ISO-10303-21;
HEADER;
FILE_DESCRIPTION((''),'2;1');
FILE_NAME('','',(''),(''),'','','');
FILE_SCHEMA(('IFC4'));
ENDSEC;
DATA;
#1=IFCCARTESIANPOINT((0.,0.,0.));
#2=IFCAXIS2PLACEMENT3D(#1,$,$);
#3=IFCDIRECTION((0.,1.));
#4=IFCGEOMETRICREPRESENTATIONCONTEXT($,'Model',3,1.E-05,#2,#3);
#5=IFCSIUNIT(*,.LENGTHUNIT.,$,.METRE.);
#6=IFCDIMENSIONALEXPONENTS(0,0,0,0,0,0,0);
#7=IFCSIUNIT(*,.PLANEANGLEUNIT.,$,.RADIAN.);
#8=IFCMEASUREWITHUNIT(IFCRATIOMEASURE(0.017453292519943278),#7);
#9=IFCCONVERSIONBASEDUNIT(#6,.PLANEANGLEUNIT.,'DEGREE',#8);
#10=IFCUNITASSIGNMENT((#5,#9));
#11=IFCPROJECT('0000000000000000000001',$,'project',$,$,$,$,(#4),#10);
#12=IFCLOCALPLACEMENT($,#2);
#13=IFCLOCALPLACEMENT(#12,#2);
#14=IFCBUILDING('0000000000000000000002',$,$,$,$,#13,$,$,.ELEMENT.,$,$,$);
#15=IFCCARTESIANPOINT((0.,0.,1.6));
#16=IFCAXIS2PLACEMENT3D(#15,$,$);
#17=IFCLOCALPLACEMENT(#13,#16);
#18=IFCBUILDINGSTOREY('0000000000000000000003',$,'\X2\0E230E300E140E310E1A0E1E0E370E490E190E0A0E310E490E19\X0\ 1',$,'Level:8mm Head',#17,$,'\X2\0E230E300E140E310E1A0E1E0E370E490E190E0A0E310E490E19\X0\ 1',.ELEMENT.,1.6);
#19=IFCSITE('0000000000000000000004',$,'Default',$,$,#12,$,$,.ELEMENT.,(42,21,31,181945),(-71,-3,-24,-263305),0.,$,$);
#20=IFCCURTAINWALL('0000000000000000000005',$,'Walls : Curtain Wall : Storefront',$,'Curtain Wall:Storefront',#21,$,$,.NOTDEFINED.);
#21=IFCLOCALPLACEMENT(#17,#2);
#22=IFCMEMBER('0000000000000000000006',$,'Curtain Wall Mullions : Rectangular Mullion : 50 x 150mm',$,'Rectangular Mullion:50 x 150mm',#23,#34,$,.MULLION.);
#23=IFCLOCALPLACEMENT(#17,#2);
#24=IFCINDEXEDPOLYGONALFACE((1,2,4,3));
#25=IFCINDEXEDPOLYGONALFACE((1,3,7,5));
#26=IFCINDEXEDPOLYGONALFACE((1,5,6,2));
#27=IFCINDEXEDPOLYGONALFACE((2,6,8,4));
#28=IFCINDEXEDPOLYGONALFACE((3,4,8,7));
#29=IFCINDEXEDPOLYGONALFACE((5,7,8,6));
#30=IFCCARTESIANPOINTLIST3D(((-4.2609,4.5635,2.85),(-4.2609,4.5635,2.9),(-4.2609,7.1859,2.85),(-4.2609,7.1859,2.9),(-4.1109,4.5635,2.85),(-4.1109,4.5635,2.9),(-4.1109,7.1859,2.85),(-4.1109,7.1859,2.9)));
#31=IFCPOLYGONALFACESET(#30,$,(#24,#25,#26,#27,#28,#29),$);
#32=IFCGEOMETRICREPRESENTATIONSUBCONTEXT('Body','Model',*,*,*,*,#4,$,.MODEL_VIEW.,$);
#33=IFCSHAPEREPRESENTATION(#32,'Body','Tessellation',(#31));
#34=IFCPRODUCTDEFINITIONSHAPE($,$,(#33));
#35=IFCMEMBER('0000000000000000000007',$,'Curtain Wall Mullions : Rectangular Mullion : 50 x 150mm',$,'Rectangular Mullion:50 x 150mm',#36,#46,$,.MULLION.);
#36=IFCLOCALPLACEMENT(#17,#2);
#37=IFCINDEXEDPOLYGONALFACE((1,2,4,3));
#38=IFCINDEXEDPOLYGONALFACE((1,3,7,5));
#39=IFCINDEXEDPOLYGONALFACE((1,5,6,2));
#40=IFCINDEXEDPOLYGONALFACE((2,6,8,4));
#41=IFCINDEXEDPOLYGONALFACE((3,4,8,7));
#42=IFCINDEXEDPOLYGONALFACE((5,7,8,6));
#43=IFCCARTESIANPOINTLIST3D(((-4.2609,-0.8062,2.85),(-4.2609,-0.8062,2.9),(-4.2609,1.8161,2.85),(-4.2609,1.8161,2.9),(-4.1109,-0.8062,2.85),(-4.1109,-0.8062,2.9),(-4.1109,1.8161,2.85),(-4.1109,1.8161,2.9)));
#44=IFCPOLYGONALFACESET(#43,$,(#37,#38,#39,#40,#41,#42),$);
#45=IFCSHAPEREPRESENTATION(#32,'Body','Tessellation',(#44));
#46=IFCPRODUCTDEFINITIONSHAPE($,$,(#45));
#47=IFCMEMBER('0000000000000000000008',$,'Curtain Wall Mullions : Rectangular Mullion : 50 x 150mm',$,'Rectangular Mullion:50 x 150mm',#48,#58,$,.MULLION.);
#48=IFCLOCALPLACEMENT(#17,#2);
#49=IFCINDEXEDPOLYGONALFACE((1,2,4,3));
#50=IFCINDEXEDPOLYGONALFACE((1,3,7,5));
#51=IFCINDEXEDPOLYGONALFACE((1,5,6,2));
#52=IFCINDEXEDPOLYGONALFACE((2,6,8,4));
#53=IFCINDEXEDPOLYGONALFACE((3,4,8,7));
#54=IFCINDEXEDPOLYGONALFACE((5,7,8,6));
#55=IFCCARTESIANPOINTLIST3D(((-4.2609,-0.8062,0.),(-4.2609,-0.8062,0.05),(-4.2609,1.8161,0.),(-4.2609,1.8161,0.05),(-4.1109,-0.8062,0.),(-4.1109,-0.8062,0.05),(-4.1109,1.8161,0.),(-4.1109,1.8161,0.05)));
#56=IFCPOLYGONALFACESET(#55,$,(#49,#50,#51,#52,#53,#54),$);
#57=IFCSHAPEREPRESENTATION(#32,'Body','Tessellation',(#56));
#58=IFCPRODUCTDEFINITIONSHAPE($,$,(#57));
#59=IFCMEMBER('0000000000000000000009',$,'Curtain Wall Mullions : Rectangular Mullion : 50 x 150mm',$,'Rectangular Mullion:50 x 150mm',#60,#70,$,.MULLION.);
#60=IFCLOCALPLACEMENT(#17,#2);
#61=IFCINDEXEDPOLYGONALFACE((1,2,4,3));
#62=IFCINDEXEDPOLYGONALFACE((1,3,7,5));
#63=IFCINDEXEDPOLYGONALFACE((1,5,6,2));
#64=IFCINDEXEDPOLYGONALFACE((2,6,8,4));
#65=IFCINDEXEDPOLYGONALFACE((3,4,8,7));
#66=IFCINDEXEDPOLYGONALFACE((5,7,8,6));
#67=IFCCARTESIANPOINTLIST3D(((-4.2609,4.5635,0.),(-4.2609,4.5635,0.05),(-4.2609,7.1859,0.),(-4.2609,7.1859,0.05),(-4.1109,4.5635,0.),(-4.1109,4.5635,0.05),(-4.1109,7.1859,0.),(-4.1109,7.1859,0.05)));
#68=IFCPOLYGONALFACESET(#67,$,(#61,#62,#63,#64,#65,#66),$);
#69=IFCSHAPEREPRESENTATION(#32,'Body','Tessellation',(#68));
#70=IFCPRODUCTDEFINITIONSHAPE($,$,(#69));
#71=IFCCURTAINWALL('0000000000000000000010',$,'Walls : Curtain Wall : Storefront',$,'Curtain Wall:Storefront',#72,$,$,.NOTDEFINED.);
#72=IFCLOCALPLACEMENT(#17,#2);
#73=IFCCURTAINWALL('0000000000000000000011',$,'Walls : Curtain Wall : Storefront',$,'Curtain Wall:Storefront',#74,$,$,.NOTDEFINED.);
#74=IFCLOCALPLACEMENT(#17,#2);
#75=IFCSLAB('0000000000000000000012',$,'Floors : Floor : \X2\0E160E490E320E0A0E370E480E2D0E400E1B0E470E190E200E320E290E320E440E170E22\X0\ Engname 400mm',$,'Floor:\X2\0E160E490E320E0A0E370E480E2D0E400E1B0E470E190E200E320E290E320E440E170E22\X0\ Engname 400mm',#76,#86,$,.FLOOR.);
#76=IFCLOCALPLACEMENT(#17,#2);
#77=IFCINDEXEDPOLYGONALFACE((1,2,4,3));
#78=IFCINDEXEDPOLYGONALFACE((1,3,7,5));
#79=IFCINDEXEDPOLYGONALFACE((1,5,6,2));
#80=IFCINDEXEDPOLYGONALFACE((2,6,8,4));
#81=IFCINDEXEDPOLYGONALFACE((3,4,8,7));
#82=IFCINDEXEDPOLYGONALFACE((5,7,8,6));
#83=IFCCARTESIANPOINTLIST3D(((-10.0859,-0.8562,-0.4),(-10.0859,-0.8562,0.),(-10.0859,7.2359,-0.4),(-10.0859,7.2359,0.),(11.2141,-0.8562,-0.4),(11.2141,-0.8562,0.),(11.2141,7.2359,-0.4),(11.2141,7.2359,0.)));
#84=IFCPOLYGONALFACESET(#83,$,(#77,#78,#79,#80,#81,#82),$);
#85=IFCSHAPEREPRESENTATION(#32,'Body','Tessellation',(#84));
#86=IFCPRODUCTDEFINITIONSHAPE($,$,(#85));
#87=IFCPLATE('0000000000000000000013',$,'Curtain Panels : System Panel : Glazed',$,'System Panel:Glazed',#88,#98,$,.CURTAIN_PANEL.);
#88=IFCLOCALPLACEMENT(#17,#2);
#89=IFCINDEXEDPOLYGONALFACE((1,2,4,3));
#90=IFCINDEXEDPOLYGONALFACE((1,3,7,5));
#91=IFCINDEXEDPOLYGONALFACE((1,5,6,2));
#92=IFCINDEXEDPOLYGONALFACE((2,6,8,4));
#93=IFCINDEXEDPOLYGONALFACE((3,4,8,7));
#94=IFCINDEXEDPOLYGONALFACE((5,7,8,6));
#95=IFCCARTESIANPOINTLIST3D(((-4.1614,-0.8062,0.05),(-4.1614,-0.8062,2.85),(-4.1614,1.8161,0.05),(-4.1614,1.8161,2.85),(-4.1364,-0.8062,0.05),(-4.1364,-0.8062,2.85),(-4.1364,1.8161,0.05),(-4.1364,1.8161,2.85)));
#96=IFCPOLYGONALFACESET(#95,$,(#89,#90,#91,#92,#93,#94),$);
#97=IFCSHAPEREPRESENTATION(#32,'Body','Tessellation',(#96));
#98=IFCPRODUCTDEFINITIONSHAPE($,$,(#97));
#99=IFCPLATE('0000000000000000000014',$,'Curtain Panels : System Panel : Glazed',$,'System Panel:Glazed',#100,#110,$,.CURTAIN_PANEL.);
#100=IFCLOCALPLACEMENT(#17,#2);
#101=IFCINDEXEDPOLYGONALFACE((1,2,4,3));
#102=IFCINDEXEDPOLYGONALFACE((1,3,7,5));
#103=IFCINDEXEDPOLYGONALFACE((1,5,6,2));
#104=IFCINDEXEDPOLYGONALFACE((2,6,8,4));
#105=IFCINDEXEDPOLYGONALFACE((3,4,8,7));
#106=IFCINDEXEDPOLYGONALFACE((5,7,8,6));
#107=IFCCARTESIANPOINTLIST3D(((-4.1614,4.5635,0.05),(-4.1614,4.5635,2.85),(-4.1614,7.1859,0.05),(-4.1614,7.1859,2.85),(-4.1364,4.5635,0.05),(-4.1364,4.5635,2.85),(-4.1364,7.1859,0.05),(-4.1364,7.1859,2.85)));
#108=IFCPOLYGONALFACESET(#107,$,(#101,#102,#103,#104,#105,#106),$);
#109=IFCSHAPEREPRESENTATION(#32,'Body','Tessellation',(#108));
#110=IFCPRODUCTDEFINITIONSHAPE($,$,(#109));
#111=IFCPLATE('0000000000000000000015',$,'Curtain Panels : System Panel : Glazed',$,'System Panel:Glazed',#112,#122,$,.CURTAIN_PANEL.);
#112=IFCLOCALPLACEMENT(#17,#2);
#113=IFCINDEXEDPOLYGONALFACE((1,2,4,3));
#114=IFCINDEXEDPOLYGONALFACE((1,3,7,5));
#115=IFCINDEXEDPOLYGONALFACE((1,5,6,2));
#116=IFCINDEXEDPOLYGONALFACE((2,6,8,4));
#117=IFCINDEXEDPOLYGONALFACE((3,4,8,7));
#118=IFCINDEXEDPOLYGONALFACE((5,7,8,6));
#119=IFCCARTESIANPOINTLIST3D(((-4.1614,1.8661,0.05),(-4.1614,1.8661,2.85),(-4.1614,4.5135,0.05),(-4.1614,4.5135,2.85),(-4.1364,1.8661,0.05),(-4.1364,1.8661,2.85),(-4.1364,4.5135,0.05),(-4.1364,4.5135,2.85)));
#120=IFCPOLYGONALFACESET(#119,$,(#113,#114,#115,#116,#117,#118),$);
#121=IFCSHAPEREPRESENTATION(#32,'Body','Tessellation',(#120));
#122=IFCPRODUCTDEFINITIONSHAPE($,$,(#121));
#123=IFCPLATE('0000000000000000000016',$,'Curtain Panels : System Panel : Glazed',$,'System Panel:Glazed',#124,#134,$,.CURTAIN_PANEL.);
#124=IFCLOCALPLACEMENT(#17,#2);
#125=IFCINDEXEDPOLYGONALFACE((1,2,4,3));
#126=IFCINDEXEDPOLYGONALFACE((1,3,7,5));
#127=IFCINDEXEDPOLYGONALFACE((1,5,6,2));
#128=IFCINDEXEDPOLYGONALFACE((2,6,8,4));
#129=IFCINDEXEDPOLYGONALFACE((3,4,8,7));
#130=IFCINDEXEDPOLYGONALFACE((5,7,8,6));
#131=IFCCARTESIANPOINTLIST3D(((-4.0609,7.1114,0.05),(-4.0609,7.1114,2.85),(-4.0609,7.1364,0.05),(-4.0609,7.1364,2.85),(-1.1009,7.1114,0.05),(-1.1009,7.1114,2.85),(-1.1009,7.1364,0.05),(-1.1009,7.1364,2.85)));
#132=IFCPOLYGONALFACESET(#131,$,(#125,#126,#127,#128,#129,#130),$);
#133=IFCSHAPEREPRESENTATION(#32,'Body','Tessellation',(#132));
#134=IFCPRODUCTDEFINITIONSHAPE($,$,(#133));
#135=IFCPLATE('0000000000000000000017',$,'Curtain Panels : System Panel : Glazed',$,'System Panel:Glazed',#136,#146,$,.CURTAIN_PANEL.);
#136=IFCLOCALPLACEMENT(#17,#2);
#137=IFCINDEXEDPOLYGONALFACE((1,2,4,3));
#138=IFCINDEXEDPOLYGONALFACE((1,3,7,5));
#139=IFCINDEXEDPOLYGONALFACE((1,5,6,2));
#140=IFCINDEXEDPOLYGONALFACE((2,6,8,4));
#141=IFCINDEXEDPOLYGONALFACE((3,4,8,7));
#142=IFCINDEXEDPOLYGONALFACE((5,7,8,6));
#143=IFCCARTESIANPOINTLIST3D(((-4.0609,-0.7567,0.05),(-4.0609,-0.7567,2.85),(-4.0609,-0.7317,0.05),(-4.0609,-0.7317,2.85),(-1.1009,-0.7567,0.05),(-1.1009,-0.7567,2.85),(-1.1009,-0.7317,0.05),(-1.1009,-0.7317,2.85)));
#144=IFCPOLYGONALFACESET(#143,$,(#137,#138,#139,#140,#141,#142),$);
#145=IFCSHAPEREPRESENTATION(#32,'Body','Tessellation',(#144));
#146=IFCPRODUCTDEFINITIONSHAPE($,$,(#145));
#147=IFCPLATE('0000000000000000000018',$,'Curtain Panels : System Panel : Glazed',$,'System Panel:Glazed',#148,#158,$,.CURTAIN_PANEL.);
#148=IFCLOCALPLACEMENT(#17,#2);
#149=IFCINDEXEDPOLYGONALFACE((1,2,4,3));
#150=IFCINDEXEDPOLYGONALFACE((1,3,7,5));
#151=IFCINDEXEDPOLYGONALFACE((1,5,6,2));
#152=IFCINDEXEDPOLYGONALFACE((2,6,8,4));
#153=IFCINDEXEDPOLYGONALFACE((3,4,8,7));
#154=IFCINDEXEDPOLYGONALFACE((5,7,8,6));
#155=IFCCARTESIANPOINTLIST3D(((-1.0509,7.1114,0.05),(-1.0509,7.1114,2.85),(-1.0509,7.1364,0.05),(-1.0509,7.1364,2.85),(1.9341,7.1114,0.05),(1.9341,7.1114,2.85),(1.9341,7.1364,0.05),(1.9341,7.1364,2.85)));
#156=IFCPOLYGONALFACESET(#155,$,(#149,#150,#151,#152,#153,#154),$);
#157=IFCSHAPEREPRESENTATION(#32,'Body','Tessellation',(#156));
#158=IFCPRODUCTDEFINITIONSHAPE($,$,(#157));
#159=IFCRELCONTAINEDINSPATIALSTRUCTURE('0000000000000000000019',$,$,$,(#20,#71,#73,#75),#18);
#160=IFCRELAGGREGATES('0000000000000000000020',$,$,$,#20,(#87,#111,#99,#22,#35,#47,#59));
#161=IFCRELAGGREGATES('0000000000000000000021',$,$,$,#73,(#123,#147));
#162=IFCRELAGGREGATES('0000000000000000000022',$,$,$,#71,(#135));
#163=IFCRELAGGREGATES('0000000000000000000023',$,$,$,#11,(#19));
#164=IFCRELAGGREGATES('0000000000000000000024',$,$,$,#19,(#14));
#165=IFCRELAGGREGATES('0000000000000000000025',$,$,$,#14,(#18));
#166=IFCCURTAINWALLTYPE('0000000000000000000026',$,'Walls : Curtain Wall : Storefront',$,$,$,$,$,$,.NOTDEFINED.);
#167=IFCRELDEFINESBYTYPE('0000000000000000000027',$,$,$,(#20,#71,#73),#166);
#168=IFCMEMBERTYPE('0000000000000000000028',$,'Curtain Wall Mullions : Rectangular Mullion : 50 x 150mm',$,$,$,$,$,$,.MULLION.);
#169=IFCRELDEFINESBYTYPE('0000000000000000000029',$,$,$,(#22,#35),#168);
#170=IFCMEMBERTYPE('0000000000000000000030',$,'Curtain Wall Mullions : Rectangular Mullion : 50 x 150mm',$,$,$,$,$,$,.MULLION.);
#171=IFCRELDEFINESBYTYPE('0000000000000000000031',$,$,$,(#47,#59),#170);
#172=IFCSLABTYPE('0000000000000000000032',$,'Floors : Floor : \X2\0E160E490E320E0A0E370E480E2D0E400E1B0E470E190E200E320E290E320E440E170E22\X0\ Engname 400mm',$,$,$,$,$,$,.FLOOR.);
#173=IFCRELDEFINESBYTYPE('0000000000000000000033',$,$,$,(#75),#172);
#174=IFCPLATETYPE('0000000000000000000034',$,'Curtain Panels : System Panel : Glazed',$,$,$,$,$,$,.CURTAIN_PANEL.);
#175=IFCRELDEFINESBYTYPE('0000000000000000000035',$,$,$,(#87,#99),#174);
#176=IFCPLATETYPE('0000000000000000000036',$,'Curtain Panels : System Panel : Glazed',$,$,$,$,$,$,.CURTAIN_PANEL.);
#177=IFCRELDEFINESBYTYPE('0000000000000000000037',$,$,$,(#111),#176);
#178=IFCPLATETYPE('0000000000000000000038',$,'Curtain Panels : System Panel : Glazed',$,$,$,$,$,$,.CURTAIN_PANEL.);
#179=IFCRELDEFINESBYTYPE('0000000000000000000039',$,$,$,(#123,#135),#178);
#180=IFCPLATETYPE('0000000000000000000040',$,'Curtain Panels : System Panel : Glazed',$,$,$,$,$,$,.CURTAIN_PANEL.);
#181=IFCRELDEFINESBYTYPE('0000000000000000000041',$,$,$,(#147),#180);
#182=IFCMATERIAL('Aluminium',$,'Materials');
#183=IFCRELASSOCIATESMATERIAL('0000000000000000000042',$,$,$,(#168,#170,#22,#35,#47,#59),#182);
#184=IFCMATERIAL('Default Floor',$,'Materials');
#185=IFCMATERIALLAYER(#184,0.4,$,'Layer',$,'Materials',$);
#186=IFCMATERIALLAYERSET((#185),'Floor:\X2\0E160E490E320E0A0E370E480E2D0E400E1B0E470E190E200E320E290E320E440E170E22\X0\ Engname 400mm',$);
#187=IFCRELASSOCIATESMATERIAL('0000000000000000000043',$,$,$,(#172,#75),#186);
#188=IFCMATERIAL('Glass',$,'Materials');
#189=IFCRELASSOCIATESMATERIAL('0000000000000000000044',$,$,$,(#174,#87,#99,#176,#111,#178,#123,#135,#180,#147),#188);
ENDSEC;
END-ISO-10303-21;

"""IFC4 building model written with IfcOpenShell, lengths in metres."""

from ifc_helpers import new_model, entity, si_unit, converted_unit, direction, frame, frame_2d, origin, origin_2d_with_axis, place, context, subcontext, project, spatial, polyline, segment, composite_curve, rectangle, outline, extrude, source, transform, mapped, material, layer, layer_set, layer_usage, material_profile, profile_set, profile_usage, type_object, type_shapes, element, aggregate, save


model = new_model("IFC4")

# Units and contexts
model_context = context("Model", 3, precision=1e-05, world=origin(), true_north=direction((0.0, 1.0)))
body_context = subcontext(model_context, "Body", "Model", "MODEL_VIEW")
ifc_project = project(units=[si_unit("LENGTHUNIT", "METRE"), converted_unit("PLANEANGLEUNIT", "DEGREE", entity("IfcRatioMeasure", 0.017453292519943278), si_unit("PLANEANGLEUNIT", "RADIAN"), dimensions=[0, 0, 0, 0, 0, 0, 0])], contexts=[model_context])

# Site, building, storey
site_placement = place(None, origin())
site = spatial("IfcSite", under=ifc_project, at=site_placement, Name="Default", CompositionType="ELEMENT", RefLatitude=(42, 21, 31, 181945), RefLongitude=(-71, -3, -24, -263305), RefElevation=0.0)
building_placement = place(site_placement, origin())
building = spatial("IfcBuilding", under=site, at=building_placement, CompositionType="ELEMENT")
storey_placement = place(building_placement, frame((0.0, 0.0, 1.6)))
storey = spatial("IfcBuildingStorey", under=building, at=storey_placement, Name="ระดับพื้นชั้น 1", ObjectType="Level:8mm Head", LongName="ระดับพื้นชั้น 1", CompositionType="ELEMENT", Elevation=1.6)

# Curtain wall, members
curtain_wall_type = type_object("IfcCurtainWallType", Name="Walls : Curtain Wall : Storefront", PredefinedType="NOTDEFINED")
curtain_wall_1_placement = place(storey_placement, frame((0.0, 0.0, -1.6)))
curtain_wall_1 = element("IfcCurtainWall", 1, at=curtain_wall_1_placement, inside=storey, type_object=curtain_wall_type, Name="Walls : Curtain Wall : Storefront", ObjectType="Curtain Wall:Storefront", PredefinedType="NOTDEFINED")
ifc_material_1 = material(Name="Aluminium", Category="Materials")
ifc_material_profile = material_profile(ifc_material_1, outline(composite_curve([segment(polyline([(0.0, 0.075, -2.6224), (0.0, -0.075, -2.6224)]), True, "CONTINUOUS"), segment(polyline([(0.0, -0.075, -2.6224), (-0.05, -0.075, -2.6224)]), True, "CONTINUOUS"), segment(polyline([(-0.05, -0.075, -2.6224), (-0.05, 0.075, -2.6224)]), True, "CONTINUOUS"), segment(polyline([(-0.05, 0.075, -2.6224), (0.0, 0.075, -2.6224)]), True, "CONTINUOUS")], self_intersect=False), kind="CURVE"), Name="50 x 150mm")
ifc_profile_set = profile_set([ifc_material_profile], Name="50 x 150mm")
ifc_profile_usage_1 = profile_usage(ifc_profile_set)
member_type_1 = type_object("IfcMemberType", Name="Curtain Wall Mullions : Rectangular Mullion : 50 x 150mm", PredefinedType="MULLION", material=ifc_profile_set)
shared_shape_1 = source(origin(), body_context, "Body", "SweptSolid", [
    extrude(rectangle(XDim=0.15, YDim=0.05, at=origin_2d_with_axis()), frame((-0.025, 0.0, -2.6224), z_axis=(0.0, 0.0, 1.0), x_axis=(0.0, -1.0, 0.0)), (0.0, 0.0, 1.0), 2.6224),
])
type_shapes(member_type_1, [shared_shape_1])
member_1_placement = place(curtain_wall_1_placement, frame((-4.1859, 7.1859, 4.5), z_axis=(0.0, 1.0, 0.0), x_axis=(0.0, 0.0, 1.0)))
member_1 = element("IfcMember", 2, at=member_1_placement, type_object=member_type_1, material=ifc_profile_usage_1, Name="Curtain Wall Mullions : Rectangular Mullion : 50 x 150mm", ObjectType="Rectangular Mullion:50 x 150mm", PredefinedType="MULLION", context=body_context, shape_type="MappedRepresentation", body=[
    mapped(shared_shape_1, transform((0.0, 0.0, 0.0), scale=1.0)),
])
ifc_profile_usage_2 = profile_usage(ifc_profile_set)
member_2_placement = place(curtain_wall_1_placement, frame((-4.1859, 1.8161, 4.5), z_axis=(0.0, 1.0, 0.0), x_axis=(0.0, 0.0, 1.0)))
member_2 = element("IfcMember", 3, at=member_2_placement, type_object=member_type_1, material=ifc_profile_usage_2, Name="Curtain Wall Mullions : Rectangular Mullion : 50 x 150mm", ObjectType="Rectangular Mullion:50 x 150mm", PredefinedType="MULLION", context=body_context, shape_type="MappedRepresentation", body=[
    mapped(shared_shape_1, transform((0.0, 0.0, 0.0), scale=1.0)),
])
ifc_profile_usage_3 = profile_usage(ifc_profile_set)
member_type_2 = type_object("IfcMemberType", Name="Curtain Wall Mullions : Rectangular Mullion : 50 x 150mm", PredefinedType="MULLION", material=ifc_profile_set)
shared_shape_2 = source(origin(), body_context, "Body", "SweptSolid", [
    extrude(rectangle(XDim=0.15, YDim=0.05, at=origin_2d_with_axis()), frame((-0.025, 0.0, -2.6224), z_axis=(0.0, 0.0, 1.0), x_axis=(0.0, -1.0, 0.0)), (0.0, 0.0, 1.0), 2.6224),
])
type_shapes(member_type_2, [shared_shape_2])
member_3_placement = place(curtain_wall_1_placement, frame((-4.1859, -0.8062, 1.6), z_axis=(0.0, -1.0, 0.0), x_axis=(0.0, 0.0, -1.0)))
member_3 = element("IfcMember", 4, at=member_3_placement, type_object=member_type_2, material=ifc_profile_usage_3, Name="Curtain Wall Mullions : Rectangular Mullion : 50 x 150mm", ObjectType="Rectangular Mullion:50 x 150mm", PredefinedType="MULLION", context=body_context, shape_type="MappedRepresentation", body=[
    mapped(shared_shape_2, transform((0.0, 0.0, 0.0), scale=1.0)),
])
ifc_profile_usage_4 = profile_usage(ifc_profile_set)
member_4_placement = place(curtain_wall_1_placement, frame((-4.1859, 4.5635, 1.6), z_axis=(0.0, -1.0, 0.0), x_axis=(0.0, 0.0, -1.0)))
member_4 = element("IfcMember", 5, at=member_4_placement, type_object=member_type_2, material=ifc_profile_usage_4, Name="Curtain Wall Mullions : Rectangular Mullion : 50 x 150mm", ObjectType="Rectangular Mullion:50 x 150mm", PredefinedType="MULLION", context=body_context, shape_type="MappedRepresentation", body=[
    mapped(shared_shape_2, transform((0.0, 0.0, 0.0), scale=1.0)),
])

# Curtain wall
curtain_wall_2_placement = place(storey_placement, frame((0.0, 0.0, -1.6)))
curtain_wall_2 = element("IfcCurtainWall", 6, at=curtain_wall_2_placement, inside=storey, type_object=curtain_wall_type, Name="Walls : Curtain Wall : Storefront", ObjectType="Curtain Wall:Storefront", PredefinedType="NOTDEFINED")

# Curtain wall
curtain_wall_3_placement = place(storey_placement, frame((0.0, 0.0, -1.6)))
curtain_wall_3 = element("IfcCurtainWall", 7, at=curtain_wall_3_placement, inside=storey, type_object=curtain_wall_type, Name="Walls : Curtain Wall : Storefront", ObjectType="Curtain Wall:Storefront", PredefinedType="NOTDEFINED")

# Slab
ifc_material_2 = material(Name="Default Floor", Category="Materials")
ifc_layer = layer(ifc_material_2, 0.4, Name="Layer", Category="Materials")
ifc_layer_set = layer_set([ifc_layer], Name="Floor:ถ้าชื่อเป็นภาษาไทย Engname 400mm")
ifc_layer_usage = layer_usage(ifc_layer_set, "AXIS3", "POSITIVE", 0.0)
slab_type = type_object("IfcSlabType", Name="Floors : Floor : ถ้าชื่อเป็นภาษาไทย Engname 400mm", PredefinedType="FLOOR", material=ifc_layer_set)
slab_placement = place(storey_placement, origin())
element("IfcSlab", 8, at=slab_placement, inside=storey, type_object=slab_type, material=ifc_layer_usage, Name="Floors : Floor : ถ้าชื่อเป็นภาษาไทย Engname 400mm", ObjectType="Floor:ถ้าชื่อเป็นภาษาไทย Engname 400mm", PredefinedType="FLOOR", context=body_context, shape_type="SweptSolid", body=[
    extrude(rectangle(XDim=8.0921, YDim=21.3, at=origin_2d_with_axis()), frame((0.5641, 3.1898, 0.0), z_axis=(0.0, 0.0, -1.0), x_axis=(0.0, 1.0, 0.0)), (0.0, 0.0, 1.0), 0.4),
])

# Plates
ifc_material_3 = material(Name="Glass", Category="Materials")
plate_type_1 = type_object("IfcPlateType", Name="Curtain Panels : System Panel : Glazed", PredefinedType="CURTAIN_PANEL", material=ifc_material_3)
shared_shape_3 = source(origin(), body_context, "Body", "SweptSolid", [
    extrude(rectangle(XDim=0.025, YDim=2.6224, at=frame_2d((0.0, 0.0), x_axis=(1.0, 0.0))), frame((1.3112, 0.0125, 0.0), z_axis=(0.0, 0.0, 1.0), x_axis=(0.0, 1.0, 0.0)), (0.0, 0.0, 1.0), 2.8),
])
type_shapes(plate_type_1, [shared_shape_3])
plate_1_placement = place(curtain_wall_1_placement, frame((-4.1364, -0.8062, 1.65), z_axis=(0.0, 0.0, 1.0), x_axis=(0.0, 1.0, 0.0)))
plate_1 = element("IfcPlate", 9, at=plate_1_placement, type_object=plate_type_1, material=ifc_material_3, Name="Curtain Panels : System Panel : Glazed", ObjectType="System Panel:Glazed", PredefinedType="CURTAIN_PANEL", context=body_context, shape_type="MappedRepresentation", body=[
    mapped(shared_shape_3, transform((0.0, 0.0, 0.0), scale=1.0)),
])
plate_2_placement = place(curtain_wall_1_placement, frame((-4.1364, 4.5635, 1.65), z_axis=(0.0, 0.0, 1.0), x_axis=(0.0, 1.0, 0.0)))
plate_2 = element("IfcPlate", 10, at=plate_2_placement, type_object=plate_type_1, material=ifc_material_3, Name="Curtain Panels : System Panel : Glazed", ObjectType="System Panel:Glazed", PredefinedType="CURTAIN_PANEL", context=body_context, shape_type="MappedRepresentation", body=[
    mapped(shared_shape_3, transform((0.0, 0.0, 0.0), scale=1.0)),
])
plate_type_2 = type_object("IfcPlateType", Name="Curtain Panels : System Panel : Glazed", PredefinedType="CURTAIN_PANEL", material=ifc_material_3)
shared_shape_4 = source(origin(), body_context, "Body", "SweptSolid", [
    extrude(rectangle(XDim=0.025, YDim=2.6474, at=origin_2d_with_axis()), frame((1.3237, 0.0125, 0.0), z_axis=(0.0, 0.0, 1.0), x_axis=(0.0, 1.0, 0.0)), (0.0, 0.0, 1.0), 2.8),
])
type_shapes(plate_type_2, [shared_shape_4])
plate_3_placement = place(curtain_wall_1_placement, frame((-4.1364, 1.8661, 1.65), z_axis=(0.0, 0.0, 1.0), x_axis=(0.0, 1.0, 0.0)))
plate_3 = element("IfcPlate", 11, at=plate_3_placement, type_object=plate_type_2, material=ifc_material_3, Name="Curtain Panels : System Panel : Glazed", ObjectType="System Panel:Glazed", PredefinedType="CURTAIN_PANEL", context=body_context, shape_type="MappedRepresentation", body=[
    mapped(shared_shape_4, transform((0.0, 0.0, 0.0), scale=1.0)),
])
aggregate(curtain_wall_1, [plate_1, plate_3, plate_2, member_1, member_2, member_3, member_4])
plate_type_3 = type_object("IfcPlateType", Name="Curtain Panels : System Panel : Glazed", PredefinedType="CURTAIN_PANEL", material=ifc_material_3)
shared_shape_5 = source(origin(), body_context, "Body", "SweptSolid", [
    extrude(rectangle(XDim=0.025, YDim=2.96, at=frame_2d((0.0, 0.0), x_axis=(1.0, 0.0))), frame((1.48, 0.0125, 0.0), z_axis=(0.0, 0.0, 1.0), x_axis=(0.0, 1.0, 0.0)), (0.0, 0.0, 1.0), 2.8),
])
type_shapes(plate_type_3, [shared_shape_5])
plate_4_placement = place(curtain_wall_3_placement, frame((-4.0609, 7.1114, 1.65)))
plate_4 = element("IfcPlate", 12, at=plate_4_placement, type_object=plate_type_3, material=ifc_material_3, Name="Curtain Panels : System Panel : Glazed", ObjectType="System Panel:Glazed", PredefinedType="CURTAIN_PANEL", context=body_context, shape_type="MappedRepresentation", body=[
    mapped(shared_shape_5, transform((0.0, 0.0, 0.0), scale=1.0)),
])
plate_5_placement = place(curtain_wall_2_placement, frame((-1.1009, -0.7317, 1.65), z_axis=(0.0, 0.0, 1.0), x_axis=(-1.0, 0.0, 0.0)))
plate_5 = element("IfcPlate", 13, at=plate_5_placement, type_object=plate_type_3, material=ifc_material_3, Name="Curtain Panels : System Panel : Glazed", ObjectType="System Panel:Glazed", PredefinedType="CURTAIN_PANEL", context=body_context, shape_type="MappedRepresentation", body=[
    mapped(shared_shape_5, transform((0.0, 0.0, 0.0), scale=1.0)),
])
plate_type_4 = type_object("IfcPlateType", Name="Curtain Panels : System Panel : Glazed", PredefinedType="CURTAIN_PANEL", material=ifc_material_3)
shared_shape_6 = source(origin(), body_context, "Body", "SweptSolid", [
    extrude(rectangle(XDim=0.025, YDim=2.985, at=frame_2d((0.0, 0.0), x_axis=(1.0, 0.0))), frame((1.4925, 0.0125, 0.0), z_axis=(0.0, 0.0, 1.0), x_axis=(0.0, 1.0, 0.0)), (0.0, 0.0, 1.0), 2.8),
])
type_shapes(plate_type_4, [shared_shape_6])
plate_6_placement = place(curtain_wall_3_placement, frame((-1.0509, 7.1114, 1.65)))
plate_6 = element("IfcPlate", 14, at=plate_6_placement, type_object=plate_type_4, material=ifc_material_3, Name="Curtain Panels : System Panel : Glazed", ObjectType="System Panel:Glazed", PredefinedType="CURTAIN_PANEL", context=body_context, shape_type="MappedRepresentation", body=[
    mapped(shared_shape_6, transform((0.0, 0.0, 0.0), scale=1.0)),
])
aggregate(curtain_wall_3, [plate_4, plate_6])
aggregate(curtain_wall_2, [plate_5])

save(model, "model.ifc")
